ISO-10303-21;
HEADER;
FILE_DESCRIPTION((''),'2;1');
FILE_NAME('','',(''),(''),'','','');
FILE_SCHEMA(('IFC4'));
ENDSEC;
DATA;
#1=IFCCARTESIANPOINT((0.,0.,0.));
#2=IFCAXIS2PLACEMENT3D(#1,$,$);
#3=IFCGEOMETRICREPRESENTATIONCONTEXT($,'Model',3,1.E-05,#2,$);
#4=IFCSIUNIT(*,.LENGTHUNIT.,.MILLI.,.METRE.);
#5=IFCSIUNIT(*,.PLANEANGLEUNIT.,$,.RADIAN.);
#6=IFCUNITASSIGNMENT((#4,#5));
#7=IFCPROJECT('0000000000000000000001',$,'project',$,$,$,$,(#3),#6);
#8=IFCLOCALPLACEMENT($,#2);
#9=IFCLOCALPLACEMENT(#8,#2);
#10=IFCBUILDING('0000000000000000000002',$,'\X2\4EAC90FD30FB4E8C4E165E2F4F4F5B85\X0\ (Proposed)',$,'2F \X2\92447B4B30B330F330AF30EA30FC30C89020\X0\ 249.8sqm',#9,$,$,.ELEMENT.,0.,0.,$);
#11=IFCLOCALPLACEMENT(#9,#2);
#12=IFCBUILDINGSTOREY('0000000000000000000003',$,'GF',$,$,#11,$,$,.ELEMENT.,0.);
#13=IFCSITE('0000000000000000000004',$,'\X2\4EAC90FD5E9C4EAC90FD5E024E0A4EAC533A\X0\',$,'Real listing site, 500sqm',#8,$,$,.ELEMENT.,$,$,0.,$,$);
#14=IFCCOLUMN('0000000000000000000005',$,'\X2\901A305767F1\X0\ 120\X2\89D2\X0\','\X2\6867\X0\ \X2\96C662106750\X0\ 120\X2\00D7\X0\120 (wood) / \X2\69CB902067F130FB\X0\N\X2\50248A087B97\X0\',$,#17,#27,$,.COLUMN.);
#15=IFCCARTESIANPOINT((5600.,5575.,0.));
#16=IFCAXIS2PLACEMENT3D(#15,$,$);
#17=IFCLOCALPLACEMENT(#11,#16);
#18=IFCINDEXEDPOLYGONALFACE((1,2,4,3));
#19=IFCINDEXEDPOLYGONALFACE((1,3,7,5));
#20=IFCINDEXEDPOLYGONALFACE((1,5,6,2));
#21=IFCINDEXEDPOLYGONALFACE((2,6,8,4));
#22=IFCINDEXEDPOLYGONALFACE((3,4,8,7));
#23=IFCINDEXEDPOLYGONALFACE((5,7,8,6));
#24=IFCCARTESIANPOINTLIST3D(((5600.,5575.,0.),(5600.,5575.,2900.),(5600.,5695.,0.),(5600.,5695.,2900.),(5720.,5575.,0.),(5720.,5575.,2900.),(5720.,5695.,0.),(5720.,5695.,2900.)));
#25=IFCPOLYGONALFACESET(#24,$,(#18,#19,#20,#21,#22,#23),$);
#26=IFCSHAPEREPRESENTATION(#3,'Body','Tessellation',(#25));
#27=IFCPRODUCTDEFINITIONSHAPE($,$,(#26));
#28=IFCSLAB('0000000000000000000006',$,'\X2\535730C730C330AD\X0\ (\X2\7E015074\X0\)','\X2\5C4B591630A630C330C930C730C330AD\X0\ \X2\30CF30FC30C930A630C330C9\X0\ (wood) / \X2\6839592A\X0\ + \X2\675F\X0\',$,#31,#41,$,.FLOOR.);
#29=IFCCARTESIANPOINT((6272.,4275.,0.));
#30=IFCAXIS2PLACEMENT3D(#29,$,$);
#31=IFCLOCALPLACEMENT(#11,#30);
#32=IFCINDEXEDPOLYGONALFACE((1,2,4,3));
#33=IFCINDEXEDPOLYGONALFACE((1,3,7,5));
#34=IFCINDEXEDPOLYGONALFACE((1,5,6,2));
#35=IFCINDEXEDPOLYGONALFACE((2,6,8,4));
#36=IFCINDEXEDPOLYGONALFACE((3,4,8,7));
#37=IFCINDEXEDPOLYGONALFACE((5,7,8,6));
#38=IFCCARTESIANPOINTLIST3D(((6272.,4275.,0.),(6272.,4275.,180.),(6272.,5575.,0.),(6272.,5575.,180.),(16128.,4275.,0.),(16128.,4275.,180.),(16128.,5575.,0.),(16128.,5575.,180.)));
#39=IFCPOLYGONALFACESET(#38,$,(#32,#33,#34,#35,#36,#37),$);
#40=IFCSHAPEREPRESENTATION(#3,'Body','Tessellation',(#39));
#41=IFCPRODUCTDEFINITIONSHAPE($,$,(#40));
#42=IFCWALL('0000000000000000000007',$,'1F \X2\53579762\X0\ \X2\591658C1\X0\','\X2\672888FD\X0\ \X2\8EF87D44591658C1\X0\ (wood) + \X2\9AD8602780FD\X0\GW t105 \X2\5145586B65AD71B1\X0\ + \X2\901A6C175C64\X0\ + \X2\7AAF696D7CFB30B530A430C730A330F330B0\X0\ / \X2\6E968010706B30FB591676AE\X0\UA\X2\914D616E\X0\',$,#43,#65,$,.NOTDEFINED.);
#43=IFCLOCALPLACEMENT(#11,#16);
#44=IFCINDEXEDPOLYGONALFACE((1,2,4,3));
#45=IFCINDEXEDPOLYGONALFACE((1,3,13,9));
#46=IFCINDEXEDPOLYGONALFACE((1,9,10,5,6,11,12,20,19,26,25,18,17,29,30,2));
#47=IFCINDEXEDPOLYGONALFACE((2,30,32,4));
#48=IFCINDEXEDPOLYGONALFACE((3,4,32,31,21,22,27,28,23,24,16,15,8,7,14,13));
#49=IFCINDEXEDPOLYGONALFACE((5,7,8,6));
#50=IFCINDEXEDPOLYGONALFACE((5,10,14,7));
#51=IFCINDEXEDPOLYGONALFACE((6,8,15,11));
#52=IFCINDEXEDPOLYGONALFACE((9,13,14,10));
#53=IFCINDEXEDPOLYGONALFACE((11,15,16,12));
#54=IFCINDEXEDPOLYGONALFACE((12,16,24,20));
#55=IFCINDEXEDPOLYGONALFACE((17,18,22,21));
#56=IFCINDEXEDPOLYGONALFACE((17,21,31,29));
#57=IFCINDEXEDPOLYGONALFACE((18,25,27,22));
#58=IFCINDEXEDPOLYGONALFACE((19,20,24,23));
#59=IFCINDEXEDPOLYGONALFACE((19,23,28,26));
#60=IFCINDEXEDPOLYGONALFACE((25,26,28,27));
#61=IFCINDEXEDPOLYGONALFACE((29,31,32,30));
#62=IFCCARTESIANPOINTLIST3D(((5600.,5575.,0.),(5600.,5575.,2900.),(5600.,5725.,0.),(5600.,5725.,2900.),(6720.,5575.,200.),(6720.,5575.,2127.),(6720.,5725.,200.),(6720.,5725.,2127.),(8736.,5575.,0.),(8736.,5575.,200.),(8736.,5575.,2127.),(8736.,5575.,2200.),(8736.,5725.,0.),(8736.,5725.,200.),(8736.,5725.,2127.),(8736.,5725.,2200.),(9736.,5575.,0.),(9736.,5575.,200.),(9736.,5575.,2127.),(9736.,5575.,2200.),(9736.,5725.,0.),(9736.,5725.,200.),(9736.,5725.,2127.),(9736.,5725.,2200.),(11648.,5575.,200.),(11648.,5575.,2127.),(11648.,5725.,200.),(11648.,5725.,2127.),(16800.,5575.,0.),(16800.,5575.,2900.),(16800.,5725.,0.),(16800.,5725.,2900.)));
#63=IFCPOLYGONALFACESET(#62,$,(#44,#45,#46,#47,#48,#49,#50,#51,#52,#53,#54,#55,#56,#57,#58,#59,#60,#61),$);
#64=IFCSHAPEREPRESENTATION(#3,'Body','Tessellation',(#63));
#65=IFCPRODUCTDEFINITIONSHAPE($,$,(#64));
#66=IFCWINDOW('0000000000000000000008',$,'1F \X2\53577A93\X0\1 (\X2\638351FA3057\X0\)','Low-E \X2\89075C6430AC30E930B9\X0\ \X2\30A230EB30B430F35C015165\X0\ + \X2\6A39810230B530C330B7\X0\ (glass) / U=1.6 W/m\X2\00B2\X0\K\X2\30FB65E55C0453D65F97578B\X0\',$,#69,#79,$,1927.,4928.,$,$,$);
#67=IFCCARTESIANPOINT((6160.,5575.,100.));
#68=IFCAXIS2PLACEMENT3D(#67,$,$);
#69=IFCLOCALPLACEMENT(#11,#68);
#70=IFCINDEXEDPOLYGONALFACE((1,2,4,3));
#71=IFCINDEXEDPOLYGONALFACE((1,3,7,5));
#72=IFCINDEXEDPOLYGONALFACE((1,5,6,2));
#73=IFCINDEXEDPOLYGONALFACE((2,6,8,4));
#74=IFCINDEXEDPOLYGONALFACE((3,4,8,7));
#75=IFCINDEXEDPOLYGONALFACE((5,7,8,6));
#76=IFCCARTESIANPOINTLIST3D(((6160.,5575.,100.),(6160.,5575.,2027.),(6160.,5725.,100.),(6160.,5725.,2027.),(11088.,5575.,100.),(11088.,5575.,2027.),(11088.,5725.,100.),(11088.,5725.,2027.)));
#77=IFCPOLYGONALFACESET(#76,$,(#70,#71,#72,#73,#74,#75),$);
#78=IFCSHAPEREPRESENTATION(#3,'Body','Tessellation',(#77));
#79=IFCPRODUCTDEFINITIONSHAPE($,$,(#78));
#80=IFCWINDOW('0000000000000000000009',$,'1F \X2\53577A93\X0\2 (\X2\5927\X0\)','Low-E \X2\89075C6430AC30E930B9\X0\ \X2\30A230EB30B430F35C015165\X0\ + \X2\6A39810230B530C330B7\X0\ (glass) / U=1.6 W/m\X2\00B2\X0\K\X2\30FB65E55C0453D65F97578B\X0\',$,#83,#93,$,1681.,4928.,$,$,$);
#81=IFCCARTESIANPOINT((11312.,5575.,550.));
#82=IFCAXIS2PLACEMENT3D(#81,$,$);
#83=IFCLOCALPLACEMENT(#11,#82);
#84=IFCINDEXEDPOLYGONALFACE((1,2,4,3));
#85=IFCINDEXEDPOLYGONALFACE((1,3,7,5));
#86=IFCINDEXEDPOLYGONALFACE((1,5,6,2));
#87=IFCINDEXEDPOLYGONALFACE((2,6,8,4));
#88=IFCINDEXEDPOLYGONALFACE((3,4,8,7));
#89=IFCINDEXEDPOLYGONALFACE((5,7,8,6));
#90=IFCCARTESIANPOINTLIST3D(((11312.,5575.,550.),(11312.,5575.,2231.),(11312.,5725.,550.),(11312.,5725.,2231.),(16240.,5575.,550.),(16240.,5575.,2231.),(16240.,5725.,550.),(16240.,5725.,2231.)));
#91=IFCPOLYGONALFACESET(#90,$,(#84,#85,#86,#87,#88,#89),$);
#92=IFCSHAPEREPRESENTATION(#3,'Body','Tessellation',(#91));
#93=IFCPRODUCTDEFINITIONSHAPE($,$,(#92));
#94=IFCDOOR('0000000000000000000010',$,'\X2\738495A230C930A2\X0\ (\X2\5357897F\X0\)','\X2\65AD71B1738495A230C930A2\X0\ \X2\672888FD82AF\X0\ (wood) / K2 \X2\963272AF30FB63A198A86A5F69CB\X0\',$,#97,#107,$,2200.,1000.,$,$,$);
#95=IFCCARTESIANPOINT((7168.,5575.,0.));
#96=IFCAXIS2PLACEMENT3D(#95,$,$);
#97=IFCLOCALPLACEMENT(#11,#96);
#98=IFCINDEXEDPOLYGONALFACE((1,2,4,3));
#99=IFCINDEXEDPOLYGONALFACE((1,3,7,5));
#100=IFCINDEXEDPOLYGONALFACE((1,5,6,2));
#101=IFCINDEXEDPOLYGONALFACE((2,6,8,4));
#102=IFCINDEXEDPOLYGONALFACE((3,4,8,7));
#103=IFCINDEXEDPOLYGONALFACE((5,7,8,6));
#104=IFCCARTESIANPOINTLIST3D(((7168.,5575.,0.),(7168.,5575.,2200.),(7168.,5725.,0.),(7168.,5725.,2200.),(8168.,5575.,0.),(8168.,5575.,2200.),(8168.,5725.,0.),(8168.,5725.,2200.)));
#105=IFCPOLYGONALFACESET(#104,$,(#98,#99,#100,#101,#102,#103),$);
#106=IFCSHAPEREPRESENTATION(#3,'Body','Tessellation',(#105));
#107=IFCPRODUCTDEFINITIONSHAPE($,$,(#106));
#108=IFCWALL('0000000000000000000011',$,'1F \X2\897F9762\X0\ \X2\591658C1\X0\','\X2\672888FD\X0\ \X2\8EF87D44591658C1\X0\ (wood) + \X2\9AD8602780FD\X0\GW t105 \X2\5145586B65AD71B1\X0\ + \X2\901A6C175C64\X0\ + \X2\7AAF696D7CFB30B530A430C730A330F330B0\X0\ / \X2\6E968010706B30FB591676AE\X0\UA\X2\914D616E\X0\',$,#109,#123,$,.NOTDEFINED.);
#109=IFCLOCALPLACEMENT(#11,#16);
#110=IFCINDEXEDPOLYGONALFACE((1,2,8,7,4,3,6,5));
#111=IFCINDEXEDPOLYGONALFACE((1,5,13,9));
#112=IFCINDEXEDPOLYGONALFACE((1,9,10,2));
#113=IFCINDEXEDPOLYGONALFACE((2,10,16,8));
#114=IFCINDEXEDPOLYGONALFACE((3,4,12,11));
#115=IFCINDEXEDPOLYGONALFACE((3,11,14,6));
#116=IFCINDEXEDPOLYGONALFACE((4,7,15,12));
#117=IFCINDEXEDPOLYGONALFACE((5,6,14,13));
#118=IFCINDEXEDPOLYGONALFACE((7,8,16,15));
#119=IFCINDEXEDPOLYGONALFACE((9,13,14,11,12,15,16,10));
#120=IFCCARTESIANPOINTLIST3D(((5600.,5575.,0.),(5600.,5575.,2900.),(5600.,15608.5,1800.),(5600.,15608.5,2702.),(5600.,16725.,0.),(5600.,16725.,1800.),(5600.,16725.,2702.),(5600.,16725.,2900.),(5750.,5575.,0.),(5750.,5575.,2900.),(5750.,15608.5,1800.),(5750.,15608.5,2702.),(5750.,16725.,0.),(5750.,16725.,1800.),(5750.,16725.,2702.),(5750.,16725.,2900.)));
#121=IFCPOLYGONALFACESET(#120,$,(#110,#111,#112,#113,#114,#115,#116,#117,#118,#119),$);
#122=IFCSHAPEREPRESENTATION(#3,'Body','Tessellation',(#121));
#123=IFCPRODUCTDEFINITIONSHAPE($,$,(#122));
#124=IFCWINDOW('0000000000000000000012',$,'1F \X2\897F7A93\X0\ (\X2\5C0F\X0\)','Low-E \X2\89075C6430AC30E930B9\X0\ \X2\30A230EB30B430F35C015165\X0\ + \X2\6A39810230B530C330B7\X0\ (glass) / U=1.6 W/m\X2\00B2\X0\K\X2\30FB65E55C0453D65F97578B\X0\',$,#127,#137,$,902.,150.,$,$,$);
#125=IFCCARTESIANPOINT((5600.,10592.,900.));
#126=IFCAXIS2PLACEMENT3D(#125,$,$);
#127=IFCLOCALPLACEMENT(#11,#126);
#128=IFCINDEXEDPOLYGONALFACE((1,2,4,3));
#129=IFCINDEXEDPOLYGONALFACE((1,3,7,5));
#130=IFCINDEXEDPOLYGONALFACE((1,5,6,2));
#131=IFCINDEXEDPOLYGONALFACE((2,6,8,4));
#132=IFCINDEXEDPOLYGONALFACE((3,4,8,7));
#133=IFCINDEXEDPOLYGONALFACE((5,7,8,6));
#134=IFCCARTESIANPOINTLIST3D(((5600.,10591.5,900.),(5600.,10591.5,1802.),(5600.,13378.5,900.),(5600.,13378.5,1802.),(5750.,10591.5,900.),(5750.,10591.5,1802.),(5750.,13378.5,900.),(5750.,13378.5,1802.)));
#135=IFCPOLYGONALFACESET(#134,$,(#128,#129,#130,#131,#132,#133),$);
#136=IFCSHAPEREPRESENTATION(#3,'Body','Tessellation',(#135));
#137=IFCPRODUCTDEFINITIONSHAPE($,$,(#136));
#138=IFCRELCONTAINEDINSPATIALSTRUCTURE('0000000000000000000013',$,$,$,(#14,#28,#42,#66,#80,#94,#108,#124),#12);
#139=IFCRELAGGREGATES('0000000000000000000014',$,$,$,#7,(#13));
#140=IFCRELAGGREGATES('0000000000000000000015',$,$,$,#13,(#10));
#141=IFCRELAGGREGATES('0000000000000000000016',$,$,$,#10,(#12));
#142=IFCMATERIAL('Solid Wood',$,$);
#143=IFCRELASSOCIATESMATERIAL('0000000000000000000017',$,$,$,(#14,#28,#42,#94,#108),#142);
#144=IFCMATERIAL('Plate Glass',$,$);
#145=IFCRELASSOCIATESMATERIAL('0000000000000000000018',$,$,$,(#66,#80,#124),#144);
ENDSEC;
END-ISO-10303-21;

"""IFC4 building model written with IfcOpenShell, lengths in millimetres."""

from ifc_helpers import new_model, si_unit, frame, frame_2d, origin, place, context, project, spatial, rectangle, extrude, material, element, fill, save


model = new_model("IFC4")

# Units and contexts
model_context = context("Model", 3, precision=1e-05, world=origin())
ifc_project = project(units=[si_unit("LENGTHUNIT", "METRE", prefix="MILLI"), si_unit("PLANEANGLEUNIT", "RADIAN")], contexts=[model_context])

# Site, building, storey
site_placement = place(None, origin())
site = spatial("IfcSite", under=ifc_project, at=site_placement, Name="京都府京都市上京区", ObjectType="Real listing site, 500sqm", CompositionType="ELEMENT", RefElevation=0.0)
building_placement = place(site_placement, origin())
building = spatial("IfcBuilding", under=site, at=building_placement, Name="京都・二世帯住宅 (Proposed)", ObjectType="2F 鉄筋コンクリート造 249.8sqm", CompositionType="ELEMENT", ElevationOfRefHeight=0.0, ElevationOfTerrain=0.0)
storey_placement = place(building_placement, origin())
storey = spatial("IfcBuildingStorey", under=building, at=storey_placement, Name="GF", CompositionType="ELEMENT", Elevation=0.0)

# Column
ifc_material_1 = material(Name="Solid Wood")
column_placement = place(storey_placement, frame((5600.0, 5575.0, 0.0)))
element("IfcColumn", 1, at=column_placement, inside=storey, material=ifc_material_1, Name="通し柱 120角", Description="桧 集成材 120×120 (wood) / 構造柱・N値計算", PredefinedType="COLUMN", context=model_context, shape_type="SweptSolid", body=[
    extrude(rectangle(XDim=120.0, YDim=120.0, at=frame_2d((60.0, 60.0))), frame((5600.0, 5575.0, 0.0)), (0.0, 0.0, 1.0), 2900.0),
])

# Slab
slab_1_placement = place(storey_placement, frame((6272.0, 4275.0, 0.0)))
element("IfcSlab", 2, at=slab_1_placement, inside=storey, material=ifc_material_1, Name="南デッキ (縁側)", Description="屋外ウッドデッキ ハードウッド (wood) / 根太 + 束", PredefinedType="FLOOR", context=model_context, shape_type="SweptSolid", body=[
    extrude(rectangle(XDim=9856.0, YDim=1300.0, at=frame_2d((4928.0, 650.0))), frame((6272.0, 4275.0, 0.0)), (0.0, 0.0, 1.0), 180.0),
])

# Wall, openings, windows, door
wall_1_placement = place(storey_placement, frame((5600.0, 5575.0, 0.0)))
wall_1 = element("IfcWall", 3, at=wall_1_placement, inside=storey, material=ifc_material_1, Name="1F 南面 外壁", Description="木製 軸組外壁 (wood) + 高性能GW t105 充填断熱 + 通気層 + 窯業系サイディング / 準耐火・外皮UA配慮", PredefinedType="NOTDEFINED", context=model_context, shape_type="SweptSolid", body=[
    extrude(rectangle(XDim=11200.0, YDim=150.0, at=frame_2d((5600.0, 75.0))), frame((5600.0, 5575.0, 0.0)), (0.0, 0.0, 1.0), 2900.0),
])
opening_1_placement = place(storey_placement, frame((6160.0, 5575.0, 100.0)))
opening_1 = element("IfcOpeningElement", 4, at=opening_1_placement, cuts=wall_1, PredefinedType="NOTDEFINED", context=model_context, shape_type="SweptSolid", body=[
    extrude(rectangle(XDim=4928.0, YDim=150.0, at=frame_2d((2464.0, 75.0))), frame((6160.0, 5575.0, 100.0)), (0.0, 0.0, 1.0), 1927.0),
])
opening_2_placement = place(storey_placement, frame((11312.0, 5575.0, 550.0)))
opening_2 = element("IfcOpeningElement", 5, at=opening_2_placement, cuts=wall_1, PredefinedType="NOTDEFINED", context=model_context, shape_type="SweptSolid", body=[
    extrude(rectangle(XDim=4928.0, YDim=150.0, at=frame_2d((2464.0, 75.0))), frame((11312.0, 5575.0, 550.0)), (0.0, 0.0, 1.0), 1681.0),
])
opening_3_placement = place(storey_placement, frame((7168.0, 5575.0, 0.0)))
opening_3 = element("IfcOpeningElement", 6, at=opening_3_placement, cuts=wall_1, PredefinedType="NOTDEFINED", context=model_context, shape_type="SweptSolid", body=[
    extrude(rectangle(XDim=1000.0, YDim=150.0, at=frame_2d((500.0, 75.0))), frame((7168.0, 5575.0, 0.0)), (0.0, 0.0, 1.0), 2200.0),
])
ifc_material_2 = material(Name="Plate Glass")
window_1_placement = place(storey_placement, frame((6160.0, 5575.0, 100.0)))
window_1 = element("IfcWindow", 7, at=window_1_placement, inside=storey, material=ifc_material_2, Name="1F 南窓1 (掃出し)", Description="Low-E 複層ガラス アルゴン封入 + 樹脂サッシ (glass) / U=1.6 W/m²K・日射取得型", OverallHeight=1927.0, OverallWidth=4928.0, context=model_context, shape_type="SweptSolid", body=[
    extrude(rectangle(XDim=4928.0, YDim=150.0, at=frame_2d((2464.0, 75.0))), frame((6160.0, 5575.0, 100.0)), (0.0, 0.0, 1.0), 1927.0),
])
fill(opening_1, window_1)
window_2_placement = place(storey_placement, frame((11312.0, 5575.0, 550.0)))
window_2 = element("IfcWindow", 8, at=window_2_placement, inside=storey, material=ifc_material_2, Name="1F 南窓2 (大)", Description="Low-E 複層ガラス アルゴン封入 + 樹脂サッシ (glass) / U=1.6 W/m²K・日射取得型", OverallHeight=1681.0, OverallWidth=4928.0, context=model_context, shape_type="SweptSolid", body=[
    extrude(rectangle(XDim=4928.0, YDim=150.0, at=frame_2d((2464.0, 75.0))), frame((11312.0, 5575.0, 550.0)), (0.0, 0.0, 1.0), 1681.0),
])
fill(opening_2, window_2)
door_placement = place(storey_placement, frame((7168.0, 5575.0, 0.0)))
door = element("IfcDoor", 9, at=door_placement, inside=storey, material=ifc_material_1, Name="玄関ドア (南西)", Description="断熱玄関ドア 木製芯 (wood) / K2 防犯・採風機構", OverallHeight=2200.0, OverallWidth=1000.0, context=model_context, shape_type="SweptSolid", body=[
    extrude(rectangle(XDim=1000.0, YDim=150.0, at=frame_2d((500.0, 75.0))), frame((7168.0, 5575.0, 0.0)), (0.0, 0.0, 1.0), 2200.0),
])
fill(opening_3, door)

# Wall, opening, window
wall_2_placement = place(storey_placement, frame((5600.0, 5575.0, 0.0)))
wall_2 = element("IfcWall", 10, at=wall_2_placement, inside=storey, material=ifc_material_1, Name="1F 西面 外壁", Description="木製 軸組外壁 (wood) + 高性能GW t105 充填断熱 + 通気層 + 窯業系サイディング / 準耐火・外皮UA配慮", PredefinedType="NOTDEFINED", context=model_context, shape_type="SweptSolid", body=[
    extrude(rectangle(XDim=150.0, YDim=11150.0, at=frame_2d((75.0, 5575.0))), frame((5600.0, 5575.0, 0.0)), (0.0, 0.0, 1.0), 2900.0),
])
opening_4_placement = place(storey_placement, frame((5600.0, 10592.0, 900.0)))
opening_4 = element("IfcOpeningElement", 11, at=opening_4_placement, cuts=wall_2, PredefinedType="NOTDEFINED", context=model_context, shape_type="SweptSolid", body=[
    extrude(rectangle(XDim=150.0, YDim=2787.0, at=frame_2d((75.0, 1393.0))), frame((5600.0, 10592.0, 900.0)), (0.0, 0.0, 1.0), 902.0),
])
window_3_placement = place(storey_placement, frame((5600.0, 10592.0, 900.0)))
window_3 = element("IfcWindow", 12, at=window_3_placement, inside=storey, material=ifc_material_2, Name="1F 西窓 (小)", Description="Low-E 複層ガラス アルゴン封入 + 樹脂サッシ (glass) / U=1.6 W/m²K・日射取得型", OverallHeight=902.0, OverallWidth=150.0, context=model_context, shape_type="SweptSolid", body=[
    extrude(rectangle(XDim=150.0, YDim=2787.0, at=frame_2d((75.0, 1393.0))), frame((5600.0, 10592.0, 900.0)), (0.0, 0.0, 1.0), 902.0),
])
fill(opening_4, window_3)

save(model, "model.ifc")
